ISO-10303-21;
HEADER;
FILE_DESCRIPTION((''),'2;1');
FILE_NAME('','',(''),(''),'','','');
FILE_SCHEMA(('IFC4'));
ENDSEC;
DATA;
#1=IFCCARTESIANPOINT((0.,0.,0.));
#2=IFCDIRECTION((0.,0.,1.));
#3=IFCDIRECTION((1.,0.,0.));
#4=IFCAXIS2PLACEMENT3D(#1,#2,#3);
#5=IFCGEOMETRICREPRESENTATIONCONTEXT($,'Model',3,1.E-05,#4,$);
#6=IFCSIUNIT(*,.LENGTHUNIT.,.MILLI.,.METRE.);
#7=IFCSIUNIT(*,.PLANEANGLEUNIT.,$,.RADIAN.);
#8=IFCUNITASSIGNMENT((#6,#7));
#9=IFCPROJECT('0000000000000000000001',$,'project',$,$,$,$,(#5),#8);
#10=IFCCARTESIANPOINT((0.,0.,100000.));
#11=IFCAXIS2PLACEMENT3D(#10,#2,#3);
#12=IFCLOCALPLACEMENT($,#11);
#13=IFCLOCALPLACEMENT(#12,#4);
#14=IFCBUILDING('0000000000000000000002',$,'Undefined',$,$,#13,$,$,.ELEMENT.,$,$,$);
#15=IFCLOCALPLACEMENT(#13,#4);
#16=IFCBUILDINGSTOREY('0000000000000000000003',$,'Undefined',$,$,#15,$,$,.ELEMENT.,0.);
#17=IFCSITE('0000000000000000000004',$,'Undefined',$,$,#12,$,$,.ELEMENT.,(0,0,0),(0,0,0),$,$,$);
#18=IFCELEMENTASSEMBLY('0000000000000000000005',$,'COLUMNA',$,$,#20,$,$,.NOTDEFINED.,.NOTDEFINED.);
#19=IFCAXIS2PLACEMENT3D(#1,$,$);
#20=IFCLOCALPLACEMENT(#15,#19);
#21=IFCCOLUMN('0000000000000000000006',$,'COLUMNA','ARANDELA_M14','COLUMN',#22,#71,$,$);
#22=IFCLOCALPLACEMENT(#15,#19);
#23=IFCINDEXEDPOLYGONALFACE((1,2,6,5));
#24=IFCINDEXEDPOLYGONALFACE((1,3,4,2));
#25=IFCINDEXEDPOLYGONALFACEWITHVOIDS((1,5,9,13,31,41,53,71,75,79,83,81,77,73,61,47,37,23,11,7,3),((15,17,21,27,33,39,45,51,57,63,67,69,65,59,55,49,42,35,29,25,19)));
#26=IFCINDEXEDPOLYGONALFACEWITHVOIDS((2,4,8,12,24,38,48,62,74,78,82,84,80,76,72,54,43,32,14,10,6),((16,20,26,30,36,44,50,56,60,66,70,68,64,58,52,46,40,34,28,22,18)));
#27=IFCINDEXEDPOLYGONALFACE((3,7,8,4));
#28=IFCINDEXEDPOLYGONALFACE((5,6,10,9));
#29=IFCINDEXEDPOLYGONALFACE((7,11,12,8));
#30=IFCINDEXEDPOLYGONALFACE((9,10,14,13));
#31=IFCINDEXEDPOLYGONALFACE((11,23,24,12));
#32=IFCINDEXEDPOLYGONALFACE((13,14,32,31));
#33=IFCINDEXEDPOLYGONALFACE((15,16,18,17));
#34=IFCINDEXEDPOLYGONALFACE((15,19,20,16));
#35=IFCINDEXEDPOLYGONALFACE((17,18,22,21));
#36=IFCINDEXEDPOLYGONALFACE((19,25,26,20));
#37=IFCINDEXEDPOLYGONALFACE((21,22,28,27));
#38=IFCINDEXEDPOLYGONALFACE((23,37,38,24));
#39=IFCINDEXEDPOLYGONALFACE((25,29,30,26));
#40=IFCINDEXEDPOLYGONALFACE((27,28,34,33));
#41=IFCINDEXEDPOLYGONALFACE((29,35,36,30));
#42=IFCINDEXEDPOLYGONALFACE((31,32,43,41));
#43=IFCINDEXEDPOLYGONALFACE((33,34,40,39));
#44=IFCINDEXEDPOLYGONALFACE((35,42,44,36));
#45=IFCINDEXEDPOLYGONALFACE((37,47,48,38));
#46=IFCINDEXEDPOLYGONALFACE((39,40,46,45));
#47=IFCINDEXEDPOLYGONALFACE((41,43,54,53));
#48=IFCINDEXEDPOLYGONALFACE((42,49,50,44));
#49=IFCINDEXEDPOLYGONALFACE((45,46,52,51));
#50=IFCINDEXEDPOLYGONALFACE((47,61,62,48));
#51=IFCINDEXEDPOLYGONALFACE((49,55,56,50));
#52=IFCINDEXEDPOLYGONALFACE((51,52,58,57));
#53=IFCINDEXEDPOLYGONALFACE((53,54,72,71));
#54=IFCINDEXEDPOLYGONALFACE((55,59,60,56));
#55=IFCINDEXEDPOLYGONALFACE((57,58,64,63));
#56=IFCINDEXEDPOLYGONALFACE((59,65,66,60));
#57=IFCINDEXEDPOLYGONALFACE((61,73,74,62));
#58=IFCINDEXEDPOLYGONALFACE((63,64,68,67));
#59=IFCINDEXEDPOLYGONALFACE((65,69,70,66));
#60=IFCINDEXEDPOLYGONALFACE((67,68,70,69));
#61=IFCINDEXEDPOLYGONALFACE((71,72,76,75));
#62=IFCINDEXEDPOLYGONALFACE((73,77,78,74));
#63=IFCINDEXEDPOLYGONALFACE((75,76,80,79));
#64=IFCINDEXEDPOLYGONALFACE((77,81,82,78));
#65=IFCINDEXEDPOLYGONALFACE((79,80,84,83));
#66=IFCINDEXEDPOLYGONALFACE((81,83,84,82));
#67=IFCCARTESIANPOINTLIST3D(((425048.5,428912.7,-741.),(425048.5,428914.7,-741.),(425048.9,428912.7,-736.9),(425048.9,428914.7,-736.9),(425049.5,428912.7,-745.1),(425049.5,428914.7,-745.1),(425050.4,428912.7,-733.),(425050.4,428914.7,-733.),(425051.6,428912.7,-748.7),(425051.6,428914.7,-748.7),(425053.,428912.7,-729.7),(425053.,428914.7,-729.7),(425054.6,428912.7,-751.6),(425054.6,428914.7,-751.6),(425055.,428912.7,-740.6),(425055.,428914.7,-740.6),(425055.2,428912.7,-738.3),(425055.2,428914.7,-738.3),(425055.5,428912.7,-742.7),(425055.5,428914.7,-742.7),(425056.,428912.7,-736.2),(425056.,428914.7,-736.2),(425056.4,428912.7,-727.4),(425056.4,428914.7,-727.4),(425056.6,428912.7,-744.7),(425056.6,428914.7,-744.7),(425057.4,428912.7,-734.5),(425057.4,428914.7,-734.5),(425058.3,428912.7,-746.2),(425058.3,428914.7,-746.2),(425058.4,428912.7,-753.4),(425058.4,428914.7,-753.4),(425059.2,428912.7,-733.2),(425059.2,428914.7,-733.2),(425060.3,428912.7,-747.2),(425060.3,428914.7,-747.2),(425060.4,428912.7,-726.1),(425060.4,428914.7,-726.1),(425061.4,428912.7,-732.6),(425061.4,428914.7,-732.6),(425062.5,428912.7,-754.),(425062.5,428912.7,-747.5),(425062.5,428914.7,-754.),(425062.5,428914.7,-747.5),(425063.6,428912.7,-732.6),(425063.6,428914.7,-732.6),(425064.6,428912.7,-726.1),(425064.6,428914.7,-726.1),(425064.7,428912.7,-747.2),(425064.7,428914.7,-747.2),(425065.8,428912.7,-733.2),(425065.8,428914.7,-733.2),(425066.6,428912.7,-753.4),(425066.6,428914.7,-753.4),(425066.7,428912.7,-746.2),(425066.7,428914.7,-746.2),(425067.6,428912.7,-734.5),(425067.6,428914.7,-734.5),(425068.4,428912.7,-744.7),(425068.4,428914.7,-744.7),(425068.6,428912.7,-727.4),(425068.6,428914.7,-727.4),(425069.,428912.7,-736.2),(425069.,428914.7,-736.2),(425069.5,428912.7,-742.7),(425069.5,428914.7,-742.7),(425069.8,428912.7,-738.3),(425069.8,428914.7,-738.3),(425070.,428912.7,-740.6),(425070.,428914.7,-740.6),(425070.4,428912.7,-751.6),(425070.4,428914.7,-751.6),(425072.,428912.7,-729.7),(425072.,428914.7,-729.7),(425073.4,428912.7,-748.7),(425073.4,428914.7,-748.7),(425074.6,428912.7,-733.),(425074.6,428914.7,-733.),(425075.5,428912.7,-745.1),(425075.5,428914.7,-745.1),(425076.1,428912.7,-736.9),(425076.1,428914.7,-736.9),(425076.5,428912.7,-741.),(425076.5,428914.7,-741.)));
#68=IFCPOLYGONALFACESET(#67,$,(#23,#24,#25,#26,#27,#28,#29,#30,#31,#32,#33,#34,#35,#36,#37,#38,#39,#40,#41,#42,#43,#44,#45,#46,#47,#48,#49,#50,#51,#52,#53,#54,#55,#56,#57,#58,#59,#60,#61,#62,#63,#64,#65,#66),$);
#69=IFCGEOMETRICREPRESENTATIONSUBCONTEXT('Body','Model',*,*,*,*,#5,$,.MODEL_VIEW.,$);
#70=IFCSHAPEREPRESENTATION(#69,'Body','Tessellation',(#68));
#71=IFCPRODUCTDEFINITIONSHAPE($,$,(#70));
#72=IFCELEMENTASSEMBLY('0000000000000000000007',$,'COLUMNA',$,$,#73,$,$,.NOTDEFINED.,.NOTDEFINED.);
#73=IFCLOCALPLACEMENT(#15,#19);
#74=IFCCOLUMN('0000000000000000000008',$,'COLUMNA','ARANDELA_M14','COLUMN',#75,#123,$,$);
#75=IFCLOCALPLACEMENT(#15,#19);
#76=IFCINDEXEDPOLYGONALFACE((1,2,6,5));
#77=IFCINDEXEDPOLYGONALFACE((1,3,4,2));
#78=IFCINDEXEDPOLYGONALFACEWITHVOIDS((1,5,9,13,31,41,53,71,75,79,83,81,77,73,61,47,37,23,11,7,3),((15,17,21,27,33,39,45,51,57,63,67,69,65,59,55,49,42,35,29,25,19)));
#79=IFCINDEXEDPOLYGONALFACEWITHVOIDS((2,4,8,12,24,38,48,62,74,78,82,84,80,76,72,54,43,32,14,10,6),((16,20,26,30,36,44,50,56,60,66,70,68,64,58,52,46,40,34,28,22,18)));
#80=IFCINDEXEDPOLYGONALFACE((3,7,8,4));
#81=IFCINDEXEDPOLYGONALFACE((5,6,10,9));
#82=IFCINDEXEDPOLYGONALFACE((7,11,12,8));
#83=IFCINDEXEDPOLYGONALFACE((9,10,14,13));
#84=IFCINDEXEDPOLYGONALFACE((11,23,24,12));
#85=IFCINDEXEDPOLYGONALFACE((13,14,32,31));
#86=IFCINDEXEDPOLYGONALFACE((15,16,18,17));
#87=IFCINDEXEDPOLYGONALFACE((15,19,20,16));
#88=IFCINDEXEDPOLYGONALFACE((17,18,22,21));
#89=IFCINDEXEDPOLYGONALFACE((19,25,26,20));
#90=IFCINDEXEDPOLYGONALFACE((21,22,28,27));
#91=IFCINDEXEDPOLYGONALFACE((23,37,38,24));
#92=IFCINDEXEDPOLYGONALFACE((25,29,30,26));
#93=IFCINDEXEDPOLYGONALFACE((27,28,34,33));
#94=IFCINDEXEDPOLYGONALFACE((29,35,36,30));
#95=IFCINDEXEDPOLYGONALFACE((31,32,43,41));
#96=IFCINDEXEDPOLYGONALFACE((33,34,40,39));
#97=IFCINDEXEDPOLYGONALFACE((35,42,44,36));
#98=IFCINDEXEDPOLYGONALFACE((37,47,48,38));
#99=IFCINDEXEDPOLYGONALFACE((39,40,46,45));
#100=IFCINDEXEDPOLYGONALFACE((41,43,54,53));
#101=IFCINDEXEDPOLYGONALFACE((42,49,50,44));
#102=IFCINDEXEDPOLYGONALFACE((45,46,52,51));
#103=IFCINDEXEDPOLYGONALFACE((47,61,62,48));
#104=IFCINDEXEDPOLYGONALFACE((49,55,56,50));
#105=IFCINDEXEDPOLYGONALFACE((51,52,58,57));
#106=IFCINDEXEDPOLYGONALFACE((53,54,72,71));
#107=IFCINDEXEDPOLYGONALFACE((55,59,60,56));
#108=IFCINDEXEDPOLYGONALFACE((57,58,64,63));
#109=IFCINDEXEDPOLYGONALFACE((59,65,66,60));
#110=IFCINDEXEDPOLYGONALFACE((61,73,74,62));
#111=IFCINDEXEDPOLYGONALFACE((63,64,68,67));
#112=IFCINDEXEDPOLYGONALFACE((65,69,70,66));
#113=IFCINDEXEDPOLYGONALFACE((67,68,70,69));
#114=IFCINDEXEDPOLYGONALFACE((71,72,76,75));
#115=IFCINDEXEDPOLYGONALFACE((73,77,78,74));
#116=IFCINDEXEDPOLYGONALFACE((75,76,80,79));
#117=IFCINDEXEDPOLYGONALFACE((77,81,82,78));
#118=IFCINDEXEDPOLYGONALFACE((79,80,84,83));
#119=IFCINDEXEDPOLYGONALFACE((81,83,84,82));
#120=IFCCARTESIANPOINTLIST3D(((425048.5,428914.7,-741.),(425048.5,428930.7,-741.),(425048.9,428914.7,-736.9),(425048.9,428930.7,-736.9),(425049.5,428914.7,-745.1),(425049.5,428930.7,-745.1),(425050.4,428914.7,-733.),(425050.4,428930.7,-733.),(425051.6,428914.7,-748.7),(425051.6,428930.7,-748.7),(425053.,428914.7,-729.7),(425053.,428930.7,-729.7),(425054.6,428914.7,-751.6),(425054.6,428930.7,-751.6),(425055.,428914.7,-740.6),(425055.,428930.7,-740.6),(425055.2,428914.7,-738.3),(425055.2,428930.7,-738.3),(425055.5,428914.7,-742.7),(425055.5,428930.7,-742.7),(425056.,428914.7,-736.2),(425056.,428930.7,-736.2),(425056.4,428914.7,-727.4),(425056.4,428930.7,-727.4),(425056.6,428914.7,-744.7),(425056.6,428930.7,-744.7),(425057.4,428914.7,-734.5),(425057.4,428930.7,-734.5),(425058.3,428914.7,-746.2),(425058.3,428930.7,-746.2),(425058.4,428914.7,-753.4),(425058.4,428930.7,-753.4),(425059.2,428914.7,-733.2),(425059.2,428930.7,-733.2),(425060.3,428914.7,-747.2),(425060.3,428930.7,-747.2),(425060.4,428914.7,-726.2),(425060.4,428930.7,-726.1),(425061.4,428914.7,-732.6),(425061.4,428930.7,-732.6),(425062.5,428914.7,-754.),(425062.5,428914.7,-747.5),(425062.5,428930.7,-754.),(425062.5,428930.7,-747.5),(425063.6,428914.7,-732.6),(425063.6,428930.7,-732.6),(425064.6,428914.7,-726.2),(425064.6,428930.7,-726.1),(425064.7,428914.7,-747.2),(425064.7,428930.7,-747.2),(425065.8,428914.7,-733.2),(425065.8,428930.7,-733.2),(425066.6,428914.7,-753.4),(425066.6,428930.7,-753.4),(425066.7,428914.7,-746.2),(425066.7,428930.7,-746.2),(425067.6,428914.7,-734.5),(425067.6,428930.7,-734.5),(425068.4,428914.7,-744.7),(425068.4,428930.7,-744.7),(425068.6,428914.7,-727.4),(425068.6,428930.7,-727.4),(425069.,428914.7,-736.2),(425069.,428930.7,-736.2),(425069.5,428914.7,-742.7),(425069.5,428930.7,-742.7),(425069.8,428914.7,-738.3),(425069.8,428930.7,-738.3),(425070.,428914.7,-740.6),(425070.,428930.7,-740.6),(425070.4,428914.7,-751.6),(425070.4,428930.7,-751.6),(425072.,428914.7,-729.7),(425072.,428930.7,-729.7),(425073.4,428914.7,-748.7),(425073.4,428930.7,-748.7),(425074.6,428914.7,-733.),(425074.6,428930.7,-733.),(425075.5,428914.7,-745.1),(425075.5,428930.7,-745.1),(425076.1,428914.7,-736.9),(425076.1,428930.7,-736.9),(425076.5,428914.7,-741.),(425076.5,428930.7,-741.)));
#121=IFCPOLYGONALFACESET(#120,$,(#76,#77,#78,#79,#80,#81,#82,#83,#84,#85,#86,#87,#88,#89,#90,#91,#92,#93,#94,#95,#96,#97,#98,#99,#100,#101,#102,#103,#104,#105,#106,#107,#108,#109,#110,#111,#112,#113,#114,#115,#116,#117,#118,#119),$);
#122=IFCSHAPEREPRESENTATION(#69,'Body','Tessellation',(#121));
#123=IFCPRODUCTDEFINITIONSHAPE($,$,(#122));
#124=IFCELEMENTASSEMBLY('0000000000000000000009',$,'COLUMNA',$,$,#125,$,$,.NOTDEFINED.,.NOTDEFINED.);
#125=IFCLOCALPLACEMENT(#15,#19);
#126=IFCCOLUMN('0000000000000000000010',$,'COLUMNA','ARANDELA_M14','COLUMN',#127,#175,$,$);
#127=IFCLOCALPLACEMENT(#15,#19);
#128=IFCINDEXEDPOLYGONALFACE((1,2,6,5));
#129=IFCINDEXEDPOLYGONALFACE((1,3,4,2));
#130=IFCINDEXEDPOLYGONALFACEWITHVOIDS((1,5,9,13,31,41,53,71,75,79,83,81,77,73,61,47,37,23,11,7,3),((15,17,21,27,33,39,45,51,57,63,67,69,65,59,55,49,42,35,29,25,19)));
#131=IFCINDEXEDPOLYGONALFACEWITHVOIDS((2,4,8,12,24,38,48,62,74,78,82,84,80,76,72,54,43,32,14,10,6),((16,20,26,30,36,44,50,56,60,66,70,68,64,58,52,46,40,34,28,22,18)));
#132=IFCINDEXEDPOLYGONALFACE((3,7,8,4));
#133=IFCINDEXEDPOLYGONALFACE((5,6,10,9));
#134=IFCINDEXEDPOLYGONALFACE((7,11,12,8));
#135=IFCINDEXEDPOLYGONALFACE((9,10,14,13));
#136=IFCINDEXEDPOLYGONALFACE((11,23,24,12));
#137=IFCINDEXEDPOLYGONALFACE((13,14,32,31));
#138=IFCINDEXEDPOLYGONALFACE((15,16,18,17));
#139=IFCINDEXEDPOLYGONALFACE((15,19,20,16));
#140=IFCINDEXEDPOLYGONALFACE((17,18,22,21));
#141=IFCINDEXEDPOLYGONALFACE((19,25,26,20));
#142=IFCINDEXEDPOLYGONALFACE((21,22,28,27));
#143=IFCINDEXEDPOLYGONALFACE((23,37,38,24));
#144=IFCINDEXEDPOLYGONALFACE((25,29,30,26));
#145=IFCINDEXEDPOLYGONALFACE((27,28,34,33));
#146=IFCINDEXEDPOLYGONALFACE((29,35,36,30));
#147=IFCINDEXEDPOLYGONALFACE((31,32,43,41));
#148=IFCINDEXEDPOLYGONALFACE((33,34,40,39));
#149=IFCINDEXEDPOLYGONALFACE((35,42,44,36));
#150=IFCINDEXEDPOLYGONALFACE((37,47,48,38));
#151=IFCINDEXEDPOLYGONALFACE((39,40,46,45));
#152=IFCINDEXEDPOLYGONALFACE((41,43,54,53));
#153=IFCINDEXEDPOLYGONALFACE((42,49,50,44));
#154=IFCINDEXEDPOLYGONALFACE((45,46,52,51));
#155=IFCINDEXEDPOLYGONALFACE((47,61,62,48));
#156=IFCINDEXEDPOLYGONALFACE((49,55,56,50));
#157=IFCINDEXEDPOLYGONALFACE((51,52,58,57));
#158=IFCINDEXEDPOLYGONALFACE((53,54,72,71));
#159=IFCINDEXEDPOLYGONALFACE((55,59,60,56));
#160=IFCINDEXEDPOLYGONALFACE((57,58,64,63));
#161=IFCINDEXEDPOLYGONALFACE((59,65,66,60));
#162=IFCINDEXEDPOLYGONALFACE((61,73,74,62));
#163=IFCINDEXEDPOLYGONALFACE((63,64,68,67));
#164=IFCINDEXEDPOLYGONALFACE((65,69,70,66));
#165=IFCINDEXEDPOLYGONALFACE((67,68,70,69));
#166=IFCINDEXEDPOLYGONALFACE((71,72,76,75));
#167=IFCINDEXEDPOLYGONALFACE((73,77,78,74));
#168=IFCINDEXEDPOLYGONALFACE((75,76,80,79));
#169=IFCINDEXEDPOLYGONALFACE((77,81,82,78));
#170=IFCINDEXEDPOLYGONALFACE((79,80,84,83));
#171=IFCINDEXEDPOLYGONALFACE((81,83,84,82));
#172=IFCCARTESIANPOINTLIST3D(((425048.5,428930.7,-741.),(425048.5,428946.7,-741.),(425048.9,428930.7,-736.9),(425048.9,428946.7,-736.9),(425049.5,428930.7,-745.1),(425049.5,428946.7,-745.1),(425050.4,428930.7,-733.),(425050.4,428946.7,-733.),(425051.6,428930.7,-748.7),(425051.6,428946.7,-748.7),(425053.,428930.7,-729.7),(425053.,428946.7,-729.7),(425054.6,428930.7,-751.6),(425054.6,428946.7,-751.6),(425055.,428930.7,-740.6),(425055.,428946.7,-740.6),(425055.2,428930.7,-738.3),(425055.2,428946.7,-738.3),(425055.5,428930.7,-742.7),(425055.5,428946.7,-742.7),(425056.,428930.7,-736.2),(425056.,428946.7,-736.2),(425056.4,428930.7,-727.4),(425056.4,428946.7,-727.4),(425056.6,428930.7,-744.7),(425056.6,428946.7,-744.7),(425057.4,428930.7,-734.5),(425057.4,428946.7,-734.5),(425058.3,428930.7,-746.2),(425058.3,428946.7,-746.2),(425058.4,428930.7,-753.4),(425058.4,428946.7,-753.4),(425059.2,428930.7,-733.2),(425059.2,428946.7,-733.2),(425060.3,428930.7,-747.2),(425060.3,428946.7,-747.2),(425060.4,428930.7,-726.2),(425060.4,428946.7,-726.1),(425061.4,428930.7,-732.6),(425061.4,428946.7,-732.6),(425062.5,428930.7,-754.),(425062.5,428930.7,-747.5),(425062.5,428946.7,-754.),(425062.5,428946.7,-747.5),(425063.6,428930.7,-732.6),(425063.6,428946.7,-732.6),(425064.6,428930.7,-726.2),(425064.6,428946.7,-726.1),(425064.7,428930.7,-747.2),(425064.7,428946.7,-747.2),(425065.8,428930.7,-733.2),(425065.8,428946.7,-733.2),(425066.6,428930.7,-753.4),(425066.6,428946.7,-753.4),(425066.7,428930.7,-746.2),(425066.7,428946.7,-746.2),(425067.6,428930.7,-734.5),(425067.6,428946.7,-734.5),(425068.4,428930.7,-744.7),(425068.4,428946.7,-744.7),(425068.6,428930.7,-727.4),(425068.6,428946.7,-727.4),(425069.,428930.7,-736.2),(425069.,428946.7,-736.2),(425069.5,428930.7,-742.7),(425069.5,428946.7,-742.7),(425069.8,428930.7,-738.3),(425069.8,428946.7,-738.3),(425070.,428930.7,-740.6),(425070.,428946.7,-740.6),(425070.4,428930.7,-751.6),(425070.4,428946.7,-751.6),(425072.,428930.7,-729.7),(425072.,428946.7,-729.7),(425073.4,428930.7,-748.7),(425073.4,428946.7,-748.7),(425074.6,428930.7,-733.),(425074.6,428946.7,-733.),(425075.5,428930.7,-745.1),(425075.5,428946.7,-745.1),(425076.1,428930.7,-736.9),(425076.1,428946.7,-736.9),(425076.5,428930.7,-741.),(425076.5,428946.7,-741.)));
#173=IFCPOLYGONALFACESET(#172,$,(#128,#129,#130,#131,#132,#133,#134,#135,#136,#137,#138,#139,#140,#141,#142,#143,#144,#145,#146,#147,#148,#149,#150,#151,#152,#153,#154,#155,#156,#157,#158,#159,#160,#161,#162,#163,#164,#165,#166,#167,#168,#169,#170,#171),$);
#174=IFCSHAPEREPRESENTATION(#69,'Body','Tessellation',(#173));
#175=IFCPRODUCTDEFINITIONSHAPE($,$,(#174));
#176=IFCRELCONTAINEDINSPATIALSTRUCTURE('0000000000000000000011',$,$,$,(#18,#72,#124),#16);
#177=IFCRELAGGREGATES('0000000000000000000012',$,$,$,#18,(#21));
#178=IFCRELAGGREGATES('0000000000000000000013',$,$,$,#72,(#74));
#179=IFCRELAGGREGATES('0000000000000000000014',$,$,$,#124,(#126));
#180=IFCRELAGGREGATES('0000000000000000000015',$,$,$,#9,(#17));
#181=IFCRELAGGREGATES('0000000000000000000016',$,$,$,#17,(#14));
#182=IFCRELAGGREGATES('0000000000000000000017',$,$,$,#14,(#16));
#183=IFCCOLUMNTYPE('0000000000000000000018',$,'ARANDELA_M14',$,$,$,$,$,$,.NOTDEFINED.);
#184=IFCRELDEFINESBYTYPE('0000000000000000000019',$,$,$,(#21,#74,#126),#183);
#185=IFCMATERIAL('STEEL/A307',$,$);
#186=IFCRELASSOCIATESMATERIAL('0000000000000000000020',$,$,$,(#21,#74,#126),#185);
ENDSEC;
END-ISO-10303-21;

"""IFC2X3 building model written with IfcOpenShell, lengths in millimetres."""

from ifc_helpers import new_model, si_unit, frame, origin_with_axes, origin_2d_with_axis, place, context, subcontext, project, spatial, hollow_circle, extrude, material, type_object, element, aggregate, save


model = new_model("IFC2X3")

# Units and contexts
model_context = context("Model", 3, precision=1e-05, world=origin_with_axes())
body_context = subcontext(model_context, "Body", "Model", "MODEL_VIEW")
ifc_project = project(units=[si_unit("LENGTHUNIT", "METRE", prefix="MILLI"), si_unit("PLANEANGLEUNIT", "RADIAN")], contexts=[model_context])

# Site, building, storey
site_placement = place(None, frame((0.0, 0.0, 100000.0), z_axis=(0.0, 0.0, 1.0), x_axis=(1.0, 0.0, 0.0)))
site = spatial("IfcSite", under=ifc_project, at=site_placement, Name="Undefined", CompositionType="ELEMENT", RefLatitude=(0, 0, 0), RefLongitude=(0, 0, 0))
building_placement = place(site_placement, origin_with_axes())
building = spatial("IfcBuilding", under=site, at=building_placement, Name="Undefined", CompositionType="ELEMENT")
storey_placement = place(building_placement, origin_with_axes())
storey = spatial("IfcBuildingStorey", under=building, at=storey_placement, Name="Undefined", CompositionType="ELEMENT", Elevation=0.0)

# Element assemblies, columns
assembly_1_placement = place(storey_placement, origin_with_axes())
assembly_1 = element("IfcElementAssembly", 1, at=assembly_1_placement, inside=storey, Name="COLUMNA", AssemblyPlace="NOTDEFINED", PredefinedType="NOTDEFINED")
ifc_material = material(Name="STEEL/A307")
column_type_1 = type_object("IfcColumnType", Name="ARANDELA_M14", PredefinedType="NOTDEFINED")
column_1_placement = place(assembly_1_placement, frame((425062.5, 428912.7, -740.0), z_axis=(0.0, 1.0, 0.000285), x_axis=(1.0, 0.0, 0.0)))
column_1 = element("IfcColumn", 2, at=column_1_placement, type_object=column_type_1, material=ifc_material, Name="COLUMNA", Description="ARANDELA_M14", ObjectType="COLUMN", context=body_context, shape_type="SweptSolid", body=[
    extrude(hollow_circle(Radius=14.0, WallThickness=6.5, at=origin_2d_with_axis()), frame((0.0, 0.0, 2.0), z_axis=(0.0, 0.0, -1.0), x_axis=(0.0, 1.0, 0.0)), (0.0, 0.0, 1.0), 2.0),
])
aggregate(assembly_1, [column_1])
assembly_2_placement = place(storey_placement, origin_with_axes())
assembly_2 = element("IfcElementAssembly", 3, at=assembly_2_placement, inside=storey, Name="COLUMNA", AssemblyPlace="NOTDEFINED", PredefinedType="NOTDEFINED")
column_2_placement = place(assembly_2_placement, frame((425062.5, 428914.7, -740.0), z_axis=(0.0, 1.0, 0.000285), x_axis=(1.0, 0.0, 0.0)))
column_2 = element("IfcColumn", 4, at=column_2_placement, type_object=column_type_1, material=ifc_material, Name="COLUMNA", Description="ARANDELA_M14", ObjectType="COLUMN", context=body_context, shape_type="SweptSolid", body=[
    extrude(hollow_circle(Radius=14.0, WallThickness=6.5, at=origin_2d_with_axis()), frame((0.0, 0.0, 16.0), z_axis=(0.0, 0.0, -1.0), x_axis=(0.0, 1.0, 0.0)), (0.0, 0.0, 1.0), 16.0),
])
aggregate(assembly_2, [column_2])
assembly_3_placement = place(storey_placement, origin_with_axes())
assembly_3 = element("IfcElementAssembly", 5, at=assembly_3_placement, inside=storey, Name="COLUMNA", AssemblyPlace="NOTDEFINED", PredefinedType="NOTDEFINED")
column_3_placement = place(assembly_3_placement, frame((425062.5, 428930.7, -740.0), z_axis=(0.0, 1.0, 0.000285), x_axis=(1.0, 0.0, 0.0)))
column_3 = element("IfcColumn", 6, at=column_3_placement, type_object=column_type_1, material=ifc_material, Name="COLUMNA", Description="ARANDELA_M14", ObjectType="COLUMN", context=body_context, shape_type="SweptSolid", body=[
    extrude(hollow_circle(Radius=14.0, WallThickness=6.5, at=origin_2d_with_axis()), frame((0.0, 0.0, 16.0), z_axis=(0.0, 0.0, -1.0), x_axis=(0.0, 1.0, 0.0)), (0.0, 0.0, 1.0), 16.0),
])
aggregate(assembly_3, [column_3])

save(model, "model.ifc")
